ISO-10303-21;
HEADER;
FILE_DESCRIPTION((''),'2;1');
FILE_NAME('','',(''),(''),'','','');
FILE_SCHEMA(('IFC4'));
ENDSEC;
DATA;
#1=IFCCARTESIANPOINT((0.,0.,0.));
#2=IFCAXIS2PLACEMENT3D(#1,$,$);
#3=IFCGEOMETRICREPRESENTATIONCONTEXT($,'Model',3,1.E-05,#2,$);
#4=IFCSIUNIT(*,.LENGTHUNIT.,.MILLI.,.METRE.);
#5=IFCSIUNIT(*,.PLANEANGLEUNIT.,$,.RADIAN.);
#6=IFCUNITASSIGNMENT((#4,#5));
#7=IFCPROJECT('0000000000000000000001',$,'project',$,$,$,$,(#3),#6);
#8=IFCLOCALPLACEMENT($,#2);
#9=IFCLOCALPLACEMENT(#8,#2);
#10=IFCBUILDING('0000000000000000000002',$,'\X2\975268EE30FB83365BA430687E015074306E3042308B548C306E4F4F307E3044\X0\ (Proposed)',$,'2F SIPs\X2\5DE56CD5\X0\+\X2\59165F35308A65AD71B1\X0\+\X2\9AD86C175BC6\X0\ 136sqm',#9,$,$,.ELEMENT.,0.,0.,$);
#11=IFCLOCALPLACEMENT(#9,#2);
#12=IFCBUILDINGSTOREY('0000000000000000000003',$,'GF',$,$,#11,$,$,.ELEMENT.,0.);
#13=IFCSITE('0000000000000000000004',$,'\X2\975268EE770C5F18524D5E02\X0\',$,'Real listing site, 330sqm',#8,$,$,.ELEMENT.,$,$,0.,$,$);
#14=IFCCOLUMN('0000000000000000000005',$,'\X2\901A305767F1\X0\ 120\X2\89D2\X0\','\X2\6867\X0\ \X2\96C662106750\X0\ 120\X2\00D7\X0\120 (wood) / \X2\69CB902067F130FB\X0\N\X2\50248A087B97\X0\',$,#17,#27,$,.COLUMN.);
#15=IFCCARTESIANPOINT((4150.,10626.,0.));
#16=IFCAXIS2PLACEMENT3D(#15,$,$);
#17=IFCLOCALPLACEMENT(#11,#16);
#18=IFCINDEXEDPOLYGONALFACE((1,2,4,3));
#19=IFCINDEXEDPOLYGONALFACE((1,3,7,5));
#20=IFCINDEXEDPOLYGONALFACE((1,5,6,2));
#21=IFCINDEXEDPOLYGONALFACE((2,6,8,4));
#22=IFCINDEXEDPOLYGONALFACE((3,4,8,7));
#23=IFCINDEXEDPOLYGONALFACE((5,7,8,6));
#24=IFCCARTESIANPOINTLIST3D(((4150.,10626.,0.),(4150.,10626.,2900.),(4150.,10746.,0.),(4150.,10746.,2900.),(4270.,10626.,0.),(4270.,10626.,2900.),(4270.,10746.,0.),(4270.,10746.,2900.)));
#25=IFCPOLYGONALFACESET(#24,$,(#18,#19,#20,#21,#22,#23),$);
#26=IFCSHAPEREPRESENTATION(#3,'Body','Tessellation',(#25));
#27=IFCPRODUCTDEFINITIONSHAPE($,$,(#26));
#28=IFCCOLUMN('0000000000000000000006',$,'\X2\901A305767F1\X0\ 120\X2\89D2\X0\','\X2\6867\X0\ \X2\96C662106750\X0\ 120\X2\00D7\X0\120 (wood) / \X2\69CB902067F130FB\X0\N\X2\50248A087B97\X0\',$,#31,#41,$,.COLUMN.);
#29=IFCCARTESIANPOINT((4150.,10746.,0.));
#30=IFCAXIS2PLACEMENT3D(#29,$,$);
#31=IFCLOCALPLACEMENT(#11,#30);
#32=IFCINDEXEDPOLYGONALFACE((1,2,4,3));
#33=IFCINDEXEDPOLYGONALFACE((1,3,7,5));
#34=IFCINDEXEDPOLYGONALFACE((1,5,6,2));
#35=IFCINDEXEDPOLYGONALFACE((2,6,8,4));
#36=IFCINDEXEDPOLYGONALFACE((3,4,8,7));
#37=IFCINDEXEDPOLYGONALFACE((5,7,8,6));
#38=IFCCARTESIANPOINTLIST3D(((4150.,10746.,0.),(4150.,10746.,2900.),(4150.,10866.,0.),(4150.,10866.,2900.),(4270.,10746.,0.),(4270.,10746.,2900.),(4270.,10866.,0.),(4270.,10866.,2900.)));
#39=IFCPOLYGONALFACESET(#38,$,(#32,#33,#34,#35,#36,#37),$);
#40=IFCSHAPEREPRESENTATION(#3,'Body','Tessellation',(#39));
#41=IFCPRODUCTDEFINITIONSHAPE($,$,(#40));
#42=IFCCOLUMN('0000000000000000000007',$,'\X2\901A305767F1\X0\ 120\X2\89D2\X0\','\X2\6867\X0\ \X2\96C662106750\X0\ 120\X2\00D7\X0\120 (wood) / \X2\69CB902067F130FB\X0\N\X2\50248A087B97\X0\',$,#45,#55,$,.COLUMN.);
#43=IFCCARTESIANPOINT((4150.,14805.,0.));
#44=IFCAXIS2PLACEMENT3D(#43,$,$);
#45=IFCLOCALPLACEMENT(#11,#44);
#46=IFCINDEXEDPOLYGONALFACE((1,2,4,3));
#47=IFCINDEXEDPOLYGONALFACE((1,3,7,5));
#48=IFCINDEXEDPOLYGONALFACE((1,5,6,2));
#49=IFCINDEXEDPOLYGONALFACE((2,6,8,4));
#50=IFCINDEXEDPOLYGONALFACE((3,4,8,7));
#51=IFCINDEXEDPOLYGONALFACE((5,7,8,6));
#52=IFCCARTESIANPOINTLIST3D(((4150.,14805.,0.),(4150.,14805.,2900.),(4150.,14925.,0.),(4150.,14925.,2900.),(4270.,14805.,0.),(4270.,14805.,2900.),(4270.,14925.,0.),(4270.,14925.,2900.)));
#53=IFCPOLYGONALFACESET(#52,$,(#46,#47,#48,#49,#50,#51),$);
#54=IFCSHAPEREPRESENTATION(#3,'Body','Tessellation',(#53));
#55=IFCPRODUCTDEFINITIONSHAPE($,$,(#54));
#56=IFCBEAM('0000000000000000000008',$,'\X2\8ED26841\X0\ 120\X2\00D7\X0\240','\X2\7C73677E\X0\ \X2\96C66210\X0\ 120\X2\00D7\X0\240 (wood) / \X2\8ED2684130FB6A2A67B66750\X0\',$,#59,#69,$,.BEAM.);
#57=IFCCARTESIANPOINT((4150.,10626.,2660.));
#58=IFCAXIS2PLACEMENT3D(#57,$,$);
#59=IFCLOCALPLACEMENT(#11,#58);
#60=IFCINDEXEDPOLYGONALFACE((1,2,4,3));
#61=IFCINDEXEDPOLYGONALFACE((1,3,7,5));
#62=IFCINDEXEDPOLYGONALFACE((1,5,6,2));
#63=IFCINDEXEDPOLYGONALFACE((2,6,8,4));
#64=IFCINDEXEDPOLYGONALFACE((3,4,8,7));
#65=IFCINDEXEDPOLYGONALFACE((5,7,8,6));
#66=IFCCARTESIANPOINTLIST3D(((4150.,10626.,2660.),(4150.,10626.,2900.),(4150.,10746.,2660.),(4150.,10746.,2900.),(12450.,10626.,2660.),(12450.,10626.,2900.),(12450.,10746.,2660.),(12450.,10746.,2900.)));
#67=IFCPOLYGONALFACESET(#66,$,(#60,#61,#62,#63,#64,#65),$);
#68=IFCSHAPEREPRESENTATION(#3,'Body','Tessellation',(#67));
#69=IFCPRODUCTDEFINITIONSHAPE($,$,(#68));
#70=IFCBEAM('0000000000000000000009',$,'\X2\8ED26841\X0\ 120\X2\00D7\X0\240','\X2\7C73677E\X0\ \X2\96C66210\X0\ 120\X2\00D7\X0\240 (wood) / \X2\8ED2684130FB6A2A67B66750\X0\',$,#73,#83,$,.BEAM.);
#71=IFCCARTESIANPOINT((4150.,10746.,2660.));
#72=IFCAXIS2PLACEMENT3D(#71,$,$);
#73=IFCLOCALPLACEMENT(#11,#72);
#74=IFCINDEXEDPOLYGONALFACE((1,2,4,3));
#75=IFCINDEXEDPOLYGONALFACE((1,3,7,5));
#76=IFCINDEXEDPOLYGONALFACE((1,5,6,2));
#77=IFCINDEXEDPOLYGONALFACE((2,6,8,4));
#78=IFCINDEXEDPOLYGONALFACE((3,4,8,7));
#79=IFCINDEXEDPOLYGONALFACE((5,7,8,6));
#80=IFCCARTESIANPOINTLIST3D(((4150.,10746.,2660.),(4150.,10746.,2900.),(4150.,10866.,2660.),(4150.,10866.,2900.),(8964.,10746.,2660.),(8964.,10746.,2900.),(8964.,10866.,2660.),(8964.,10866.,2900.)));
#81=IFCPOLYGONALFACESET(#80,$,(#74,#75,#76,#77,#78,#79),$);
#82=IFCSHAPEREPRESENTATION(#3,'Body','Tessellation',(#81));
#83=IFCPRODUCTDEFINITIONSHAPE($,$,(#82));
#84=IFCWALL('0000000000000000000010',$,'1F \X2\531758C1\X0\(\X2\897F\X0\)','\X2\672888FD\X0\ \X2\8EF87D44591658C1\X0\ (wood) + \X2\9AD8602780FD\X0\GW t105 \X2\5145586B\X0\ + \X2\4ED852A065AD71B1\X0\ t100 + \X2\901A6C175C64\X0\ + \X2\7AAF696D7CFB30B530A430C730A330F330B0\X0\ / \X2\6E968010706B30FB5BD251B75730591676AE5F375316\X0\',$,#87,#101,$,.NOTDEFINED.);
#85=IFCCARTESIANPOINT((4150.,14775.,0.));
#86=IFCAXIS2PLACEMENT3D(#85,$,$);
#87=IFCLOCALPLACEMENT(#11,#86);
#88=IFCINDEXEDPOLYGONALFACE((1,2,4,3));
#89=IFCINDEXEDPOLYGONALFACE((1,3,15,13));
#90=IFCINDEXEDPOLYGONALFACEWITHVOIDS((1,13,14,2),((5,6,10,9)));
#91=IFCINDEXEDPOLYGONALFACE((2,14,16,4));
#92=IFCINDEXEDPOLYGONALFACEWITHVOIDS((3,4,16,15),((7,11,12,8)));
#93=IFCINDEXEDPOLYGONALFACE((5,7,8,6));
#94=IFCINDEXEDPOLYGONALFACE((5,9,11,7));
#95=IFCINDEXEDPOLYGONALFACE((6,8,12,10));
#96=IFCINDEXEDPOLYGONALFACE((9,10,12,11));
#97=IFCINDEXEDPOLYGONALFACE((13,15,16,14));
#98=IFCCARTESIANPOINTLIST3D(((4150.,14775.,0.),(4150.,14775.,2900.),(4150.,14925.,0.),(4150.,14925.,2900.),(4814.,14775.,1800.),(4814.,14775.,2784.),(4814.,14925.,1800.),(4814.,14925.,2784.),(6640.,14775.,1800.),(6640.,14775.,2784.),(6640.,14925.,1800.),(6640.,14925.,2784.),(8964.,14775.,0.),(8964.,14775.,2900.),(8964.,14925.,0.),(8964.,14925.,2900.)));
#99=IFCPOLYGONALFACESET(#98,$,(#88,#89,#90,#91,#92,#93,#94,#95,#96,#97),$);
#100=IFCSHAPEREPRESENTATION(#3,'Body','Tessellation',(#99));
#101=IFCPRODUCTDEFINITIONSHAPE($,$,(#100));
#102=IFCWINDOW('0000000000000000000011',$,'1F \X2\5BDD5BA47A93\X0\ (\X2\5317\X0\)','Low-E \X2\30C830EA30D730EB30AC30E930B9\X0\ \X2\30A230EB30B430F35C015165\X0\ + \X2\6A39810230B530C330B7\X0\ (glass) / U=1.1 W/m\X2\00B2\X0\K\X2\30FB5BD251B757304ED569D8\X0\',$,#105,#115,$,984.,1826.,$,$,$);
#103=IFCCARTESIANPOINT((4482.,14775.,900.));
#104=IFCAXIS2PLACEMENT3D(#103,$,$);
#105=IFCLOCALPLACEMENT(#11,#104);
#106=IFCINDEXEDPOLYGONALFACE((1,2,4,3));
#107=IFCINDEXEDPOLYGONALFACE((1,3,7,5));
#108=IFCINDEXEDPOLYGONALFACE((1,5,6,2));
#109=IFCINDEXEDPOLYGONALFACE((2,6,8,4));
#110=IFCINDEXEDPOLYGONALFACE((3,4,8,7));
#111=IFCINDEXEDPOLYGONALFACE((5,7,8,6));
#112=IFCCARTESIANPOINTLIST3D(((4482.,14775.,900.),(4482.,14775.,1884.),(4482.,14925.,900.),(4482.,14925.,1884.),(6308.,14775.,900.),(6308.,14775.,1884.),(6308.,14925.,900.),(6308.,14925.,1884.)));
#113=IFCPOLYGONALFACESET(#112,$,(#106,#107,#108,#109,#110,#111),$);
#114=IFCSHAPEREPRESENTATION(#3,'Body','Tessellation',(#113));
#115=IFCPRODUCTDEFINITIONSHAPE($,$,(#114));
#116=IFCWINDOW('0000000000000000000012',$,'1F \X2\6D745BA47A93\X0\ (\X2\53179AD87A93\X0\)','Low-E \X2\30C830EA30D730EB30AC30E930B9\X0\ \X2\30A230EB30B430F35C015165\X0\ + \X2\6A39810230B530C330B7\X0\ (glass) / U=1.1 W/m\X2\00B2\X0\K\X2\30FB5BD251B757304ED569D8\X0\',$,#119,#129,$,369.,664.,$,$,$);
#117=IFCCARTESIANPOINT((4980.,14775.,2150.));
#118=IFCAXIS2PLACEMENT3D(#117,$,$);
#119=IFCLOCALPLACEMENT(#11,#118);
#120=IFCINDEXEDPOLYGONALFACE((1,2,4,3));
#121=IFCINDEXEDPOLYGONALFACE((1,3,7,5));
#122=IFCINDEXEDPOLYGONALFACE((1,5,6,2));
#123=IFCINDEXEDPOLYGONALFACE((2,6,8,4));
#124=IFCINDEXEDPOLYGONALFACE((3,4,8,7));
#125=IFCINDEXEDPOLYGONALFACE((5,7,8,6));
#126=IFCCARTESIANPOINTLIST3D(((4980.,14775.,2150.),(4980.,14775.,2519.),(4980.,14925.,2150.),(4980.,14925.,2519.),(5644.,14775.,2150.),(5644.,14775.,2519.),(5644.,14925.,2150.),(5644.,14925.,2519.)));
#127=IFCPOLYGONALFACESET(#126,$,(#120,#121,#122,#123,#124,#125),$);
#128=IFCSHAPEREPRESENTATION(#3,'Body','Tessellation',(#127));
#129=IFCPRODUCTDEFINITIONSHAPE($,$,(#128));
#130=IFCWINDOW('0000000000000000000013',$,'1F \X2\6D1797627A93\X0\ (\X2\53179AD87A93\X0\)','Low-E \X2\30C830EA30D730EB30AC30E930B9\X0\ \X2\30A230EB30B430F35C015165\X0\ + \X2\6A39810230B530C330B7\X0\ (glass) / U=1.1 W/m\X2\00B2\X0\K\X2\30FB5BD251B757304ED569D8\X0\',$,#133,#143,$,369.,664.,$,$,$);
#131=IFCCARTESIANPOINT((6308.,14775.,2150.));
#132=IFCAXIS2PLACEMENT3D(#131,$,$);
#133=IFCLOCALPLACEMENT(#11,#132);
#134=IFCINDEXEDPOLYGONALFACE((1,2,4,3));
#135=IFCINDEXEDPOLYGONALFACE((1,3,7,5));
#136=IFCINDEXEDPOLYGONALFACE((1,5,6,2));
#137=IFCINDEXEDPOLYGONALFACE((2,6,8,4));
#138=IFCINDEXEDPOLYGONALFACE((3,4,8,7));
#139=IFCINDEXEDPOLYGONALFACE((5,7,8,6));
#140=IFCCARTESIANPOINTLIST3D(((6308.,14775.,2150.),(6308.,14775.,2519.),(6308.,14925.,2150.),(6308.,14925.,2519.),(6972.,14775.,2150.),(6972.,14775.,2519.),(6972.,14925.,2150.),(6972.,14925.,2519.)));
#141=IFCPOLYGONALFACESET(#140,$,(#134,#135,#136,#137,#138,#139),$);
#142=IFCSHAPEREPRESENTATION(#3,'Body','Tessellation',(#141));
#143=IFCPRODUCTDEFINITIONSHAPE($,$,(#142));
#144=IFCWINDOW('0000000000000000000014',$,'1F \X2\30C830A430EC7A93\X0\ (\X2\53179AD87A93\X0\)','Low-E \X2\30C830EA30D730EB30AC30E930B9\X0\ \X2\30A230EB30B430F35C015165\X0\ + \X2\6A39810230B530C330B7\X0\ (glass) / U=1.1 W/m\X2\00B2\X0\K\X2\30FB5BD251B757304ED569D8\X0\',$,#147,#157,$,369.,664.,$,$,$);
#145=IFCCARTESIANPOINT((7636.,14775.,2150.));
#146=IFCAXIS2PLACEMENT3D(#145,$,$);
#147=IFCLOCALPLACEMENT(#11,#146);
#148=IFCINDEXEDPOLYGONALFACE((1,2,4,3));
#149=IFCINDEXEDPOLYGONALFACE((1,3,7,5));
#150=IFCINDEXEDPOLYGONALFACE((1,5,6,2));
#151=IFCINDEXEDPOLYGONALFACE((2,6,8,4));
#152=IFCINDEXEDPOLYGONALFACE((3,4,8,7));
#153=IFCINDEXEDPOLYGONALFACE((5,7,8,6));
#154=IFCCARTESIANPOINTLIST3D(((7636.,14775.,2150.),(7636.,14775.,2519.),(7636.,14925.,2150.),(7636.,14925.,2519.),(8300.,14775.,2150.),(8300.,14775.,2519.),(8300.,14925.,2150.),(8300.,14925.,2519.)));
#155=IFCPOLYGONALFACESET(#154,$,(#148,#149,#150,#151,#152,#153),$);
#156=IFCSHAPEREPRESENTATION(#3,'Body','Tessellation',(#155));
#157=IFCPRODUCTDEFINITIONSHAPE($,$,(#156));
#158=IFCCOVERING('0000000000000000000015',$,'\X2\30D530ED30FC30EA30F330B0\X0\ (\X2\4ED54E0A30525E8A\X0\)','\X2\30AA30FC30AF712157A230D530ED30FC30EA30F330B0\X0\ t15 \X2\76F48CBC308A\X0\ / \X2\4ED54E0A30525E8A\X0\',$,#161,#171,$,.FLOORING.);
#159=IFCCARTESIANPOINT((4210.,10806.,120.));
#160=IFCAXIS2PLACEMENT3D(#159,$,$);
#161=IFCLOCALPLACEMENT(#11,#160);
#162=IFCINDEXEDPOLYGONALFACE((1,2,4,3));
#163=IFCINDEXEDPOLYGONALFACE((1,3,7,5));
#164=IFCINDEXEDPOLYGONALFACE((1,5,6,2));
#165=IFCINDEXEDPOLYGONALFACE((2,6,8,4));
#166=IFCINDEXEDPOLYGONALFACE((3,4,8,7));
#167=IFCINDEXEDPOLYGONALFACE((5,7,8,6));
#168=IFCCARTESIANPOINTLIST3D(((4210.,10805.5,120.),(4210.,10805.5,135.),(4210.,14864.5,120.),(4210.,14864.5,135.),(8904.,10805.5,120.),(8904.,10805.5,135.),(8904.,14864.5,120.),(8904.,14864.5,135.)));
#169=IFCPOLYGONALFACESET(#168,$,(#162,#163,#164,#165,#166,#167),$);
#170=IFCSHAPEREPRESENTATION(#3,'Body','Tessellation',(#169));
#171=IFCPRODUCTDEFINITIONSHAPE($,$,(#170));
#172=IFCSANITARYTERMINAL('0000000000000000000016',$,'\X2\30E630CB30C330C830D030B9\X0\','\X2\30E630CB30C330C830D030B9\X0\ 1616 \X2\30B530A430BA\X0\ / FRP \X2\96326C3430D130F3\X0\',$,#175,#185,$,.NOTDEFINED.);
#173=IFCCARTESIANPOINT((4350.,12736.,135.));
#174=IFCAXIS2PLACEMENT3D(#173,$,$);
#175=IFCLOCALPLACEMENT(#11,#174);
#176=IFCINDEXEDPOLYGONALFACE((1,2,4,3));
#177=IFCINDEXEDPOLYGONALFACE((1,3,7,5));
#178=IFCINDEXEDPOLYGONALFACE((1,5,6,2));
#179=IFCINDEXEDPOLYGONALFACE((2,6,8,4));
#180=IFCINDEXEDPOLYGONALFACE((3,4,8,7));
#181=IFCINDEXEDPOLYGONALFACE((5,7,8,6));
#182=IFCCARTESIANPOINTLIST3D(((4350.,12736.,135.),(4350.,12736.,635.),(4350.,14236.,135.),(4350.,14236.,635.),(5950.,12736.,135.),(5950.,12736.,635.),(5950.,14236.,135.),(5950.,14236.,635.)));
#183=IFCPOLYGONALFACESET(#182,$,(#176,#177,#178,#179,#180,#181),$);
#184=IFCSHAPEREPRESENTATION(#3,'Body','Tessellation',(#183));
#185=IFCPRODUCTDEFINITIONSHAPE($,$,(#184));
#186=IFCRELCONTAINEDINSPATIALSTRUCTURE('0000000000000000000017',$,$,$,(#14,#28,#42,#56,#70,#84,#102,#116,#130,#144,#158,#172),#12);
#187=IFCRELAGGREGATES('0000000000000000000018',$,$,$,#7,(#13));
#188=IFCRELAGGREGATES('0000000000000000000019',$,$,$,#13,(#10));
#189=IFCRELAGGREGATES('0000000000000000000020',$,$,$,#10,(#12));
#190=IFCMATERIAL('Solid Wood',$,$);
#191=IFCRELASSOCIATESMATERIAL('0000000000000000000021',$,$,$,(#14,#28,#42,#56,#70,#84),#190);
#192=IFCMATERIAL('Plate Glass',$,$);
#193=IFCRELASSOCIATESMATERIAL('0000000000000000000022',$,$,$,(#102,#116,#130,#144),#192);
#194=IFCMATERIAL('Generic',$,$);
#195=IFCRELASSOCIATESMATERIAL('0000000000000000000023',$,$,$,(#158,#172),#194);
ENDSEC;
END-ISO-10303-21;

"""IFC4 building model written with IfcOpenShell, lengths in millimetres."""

from ifc_helpers import new_model, si_unit, frame, frame_2d, origin, place, context, project, spatial, rectangle, extrude, material, element, fill, save


model = new_model("IFC4")

# Units and contexts
model_context = context("Model", 3, precision=1e-05, world=origin())
ifc_project = project(units=[si_unit("LENGTHUNIT", "METRE", prefix="MILLI"), si_unit("PLANEANGLEUNIT", "RADIAN")], contexts=[model_context])

# Site, building, storey
site_placement = place(None, origin())
site = spatial("IfcSite", under=ifc_project, at=site_placement, Name="青森県弘前市", ObjectType="Real listing site, 330sqm", CompositionType="ELEMENT", RefElevation=0.0)
building_placement = place(site_placement, origin())
building = spatial("IfcBuilding", under=site, at=building_placement, Name="青森・茶室と縁側のある和の住まい (Proposed)", ObjectType="2F SIPs工法+外張り断熱+高気密 136sqm", CompositionType="ELEMENT", ElevationOfRefHeight=0.0, ElevationOfTerrain=0.0)
storey_placement = place(building_placement, origin())
storey = spatial("IfcBuildingStorey", under=building, at=storey_placement, Name="GF", CompositionType="ELEMENT", Elevation=0.0)

# Columns
ifc_material_1 = material(Name="Solid Wood")
column_1_placement = place(storey_placement, frame((4150.0, 10626.0, 0.0)))
element("IfcColumn", 1, at=column_1_placement, inside=storey, material=ifc_material_1, Name="通し柱 120角", Description="桧 集成材 120×120 (wood) / 構造柱・N値計算", PredefinedType="COLUMN", context=model_context, shape_type="SweptSolid", body=[
    extrude(rectangle(XDim=120.0, YDim=120.0, at=frame_2d((60.0, 60.0))), frame((4150.0, 10626.0, 0.0)), (0.0, 0.0, 1.0), 2900.0),
])
column_2_placement = place(storey_placement, frame((4150.0, 10746.0, 0.0)))
element("IfcColumn", 2, at=column_2_placement, inside=storey, material=ifc_material_1, Name="通し柱 120角", Description="桧 集成材 120×120 (wood) / 構造柱・N値計算", PredefinedType="COLUMN", context=model_context, shape_type="SweptSolid", body=[
    extrude(rectangle(XDim=120.0, YDim=120.0, at=frame_2d((60.0, 60.0))), frame((4150.0, 10746.0, 0.0)), (0.0, 0.0, 1.0), 2900.0),
])
column_3_placement = place(storey_placement, frame((4150.0, 14805.0, 0.0)))
element("IfcColumn", 3, at=column_3_placement, inside=storey, material=ifc_material_1, Name="通し柱 120角", Description="桧 集成材 120×120 (wood) / 構造柱・N値計算", PredefinedType="COLUMN", context=model_context, shape_type="SweptSolid", body=[
    extrude(rectangle(XDim=120.0, YDim=120.0, at=frame_2d((60.0, 60.0))), frame((4150.0, 14805.0, 0.0)), (0.0, 0.0, 1.0), 2900.0),
])

# Beams
beam_1_placement = place(storey_placement, frame((4150.0, 10626.0, 2660.0)))
element("IfcBeam", 4, at=beam_1_placement, inside=storey, material=ifc_material_1, Name="軒桁 120×240", Description="米松 集成 120×240 (wood) / 軒桁・横架材", PredefinedType="BEAM", context=model_context, shape_type="SweptSolid", body=[
    extrude(rectangle(XDim=8300.0, YDim=120.0, at=frame_2d((4150.0, 60.0))), frame((4150.0, 10626.0, 2660.0)), (0.0, 0.0, 1.0), 240.0),
])
beam_2_placement = place(storey_placement, frame((4150.0, 10746.0, 2660.0)))
element("IfcBeam", 5, at=beam_2_placement, inside=storey, material=ifc_material_1, Name="軒桁 120×240", Description="米松 集成 120×240 (wood) / 軒桁・横架材", PredefinedType="BEAM", context=model_context, shape_type="SweptSolid", body=[
    extrude(rectangle(XDim=4814.0, YDim=120.0, at=frame_2d((2407.0, 60.0))), frame((4150.0, 10746.0, 2660.0)), (0.0, 0.0, 1.0), 240.0),
])

# Wall, openings, windows
wall_1_placement = place(storey_placement, frame((4150.0, 14775.0, 0.0)))
wall_1 = element("IfcWall", 6, at=wall_1_placement, inside=storey, material=ifc_material_1, Name="1F 北壁(西)", Description="木製 軸組外壁 (wood) + 高性能GW t105 充填 + 付加断熱 t100 + 通気層 + 窯業系サイディング / 準耐火・寒冷地外皮強化", PredefinedType="NOTDEFINED", context=model_context, shape_type="SweptSolid", body=[
    extrude(rectangle(XDim=4814.0, YDim=150.0, at=frame_2d((2407.0, 75.0))), frame((4150.0, 14775.0, 0.0)), (0.0, 0.0, 1.0), 2900.0),
])
opening_1_placement = place(storey_placement, frame((4482.0, 14775.0, 900.0)))
opening_1 = element("IfcOpeningElement", 7, at=opening_1_placement, cuts=wall_1, PredefinedType="NOTDEFINED", context=model_context, shape_type="SweptSolid", body=[
    extrude(rectangle(XDim=1826.0, YDim=150.0, at=frame_2d((913.0, 75.0))), frame((4482.0, 14775.0, 900.0)), (0.0, 0.0, 1.0), 984.0),
])
opening_2_placement = place(storey_placement, frame((4980.0, 14775.0, 2150.0)))
opening_2 = element("IfcOpeningElement", 8, at=opening_2_placement, cuts=wall_1, PredefinedType="NOTDEFINED", context=model_context, shape_type="SweptSolid", body=[
    extrude(rectangle(XDim=664.0, YDim=150.0, at=frame_2d((332.0, 75.0))), frame((4980.0, 14775.0, 2150.0)), (0.0, 0.0, 1.0), 369.0),
])
opening_3_placement = place(storey_placement, frame((6308.0, 14775.0, 2150.0)))
opening_3 = element("IfcOpeningElement", 9, at=opening_3_placement, cuts=wall_1, PredefinedType="NOTDEFINED", context=model_context, shape_type="SweptSolid", body=[
    extrude(rectangle(XDim=664.0, YDim=150.0, at=frame_2d((332.0, 75.0))), frame((6308.0, 14775.0, 2150.0)), (0.0, 0.0, 1.0), 369.0),
])
opening_4_placement = place(storey_placement, frame((7636.0, 14775.0, 2150.0)))
opening_4 = element("IfcOpeningElement", 10, at=opening_4_placement, cuts=wall_1, PredefinedType="NOTDEFINED", context=model_context, shape_type="SweptSolid", body=[
    extrude(rectangle(XDim=664.0, YDim=150.0, at=frame_2d((332.0, 75.0))), frame((7636.0, 14775.0, 2150.0)), (0.0, 0.0, 1.0), 369.0),
])
ifc_material_2 = material(Name="Plate Glass")
window_1_placement = place(storey_placement, frame((4482.0, 14775.0, 900.0)))
window_1 = element("IfcWindow", 11, at=window_1_placement, inside=storey, material=ifc_material_2, Name="1F 寝室窓 (北)", Description="Low-E トリプルガラス アルゴン封入 + 樹脂サッシ (glass) / U=1.1 W/m²K・寒冷地仕様", OverallHeight=984.0, OverallWidth=1826.0, context=model_context, shape_type="SweptSolid", body=[
    extrude(rectangle(XDim=1826.0, YDim=150.0, at=frame_2d((913.0, 75.0))), frame((4482.0, 14775.0, 900.0)), (0.0, 0.0, 1.0), 984.0),
])
fill(opening_1, window_1)
window_2_placement = place(storey_placement, frame((4980.0, 14775.0, 2150.0)))
window_2 = element("IfcWindow", 12, at=window_2_placement, inside=storey, material=ifc_material_2, Name="1F 浴室窓 (北高窓)", Description="Low-E トリプルガラス アルゴン封入 + 樹脂サッシ (glass) / U=1.1 W/m²K・寒冷地仕様", OverallHeight=369.0, OverallWidth=664.0, context=model_context, shape_type="SweptSolid", body=[
    extrude(rectangle(XDim=664.0, YDim=150.0, at=frame_2d((332.0, 75.0))), frame((4980.0, 14775.0, 2150.0)), (0.0, 0.0, 1.0), 369.0),
])
fill(opening_2, window_2)
window_3_placement = place(storey_placement, frame((6308.0, 14775.0, 2150.0)))
window_3 = element("IfcWindow", 13, at=window_3_placement, inside=storey, material=ifc_material_2, Name="1F 洗面窓 (北高窓)", Description="Low-E トリプルガラス アルゴン封入 + 樹脂サッシ (glass) / U=1.1 W/m²K・寒冷地仕様", OverallHeight=369.0, OverallWidth=664.0, context=model_context, shape_type="SweptSolid", body=[
    extrude(rectangle(XDim=664.0, YDim=150.0, at=frame_2d((332.0, 75.0))), frame((6308.0, 14775.0, 2150.0)), (0.0, 0.0, 1.0), 369.0),
])
fill(opening_3, window_3)
window_4_placement = place(storey_placement, frame((7636.0, 14775.0, 2150.0)))
window_4 = element("IfcWindow", 14, at=window_4_placement, inside=storey, material=ifc_material_2, Name="1F トイレ窓 (北高窓)", Description="Low-E トリプルガラス アルゴン封入 + 樹脂サッシ (glass) / U=1.1 W/m²K・寒冷地仕様", OverallHeight=369.0, OverallWidth=664.0, context=model_context, shape_type="SweptSolid", body=[
    extrude(rectangle(XDim=664.0, YDim=150.0, at=frame_2d((332.0, 75.0))), frame((7636.0, 14775.0, 2150.0)), (0.0, 0.0, 1.0), 369.0),
])
fill(opening_4, window_4)

# Covering
ifc_material_3 = material(Name="Generic")
covering_placement = place(storey_placement, frame((4210.0, 10806.0, 120.0)))
element("IfcCovering", 15, at=covering_placement, inside=storey, material=ifc_material_3, Name="フローリング (仕上げ床)", Description="オーク無垢フローリング t15 直貼り / 仕上げ床", PredefinedType="FLOORING", context=model_context, shape_type="SweptSolid", body=[
    extrude(rectangle(XDim=4694.0, YDim=4059.0, at=frame_2d((2347.0, 2029.0))), frame((4210.0, 10806.0, 120.0)), (0.0, 0.0, 1.0), 15.0),
])

# Sanitary terminal
sanitary_terminal_placement = place(storey_placement, frame((4350.0, 12736.0, 135.0)))
element("IfcSanitaryTerminal", 16, at=sanitary_terminal_placement, inside=storey, material=ifc_material_3, Name="ユニットバス", Description="ユニットバス 1616 サイズ / FRP 防水パン", PredefinedType="NOTDEFINED", context=model_context, shape_type="SweptSolid", body=[
    extrude(rectangle(XDim=1600.0, YDim=1500.0, at=frame_2d((800.0, 750.0))), frame((4350.0, 12736.0, 135.0)), (0.0, 0.0, 1.0), 500.0),
])

save(model, "model.ifc")
